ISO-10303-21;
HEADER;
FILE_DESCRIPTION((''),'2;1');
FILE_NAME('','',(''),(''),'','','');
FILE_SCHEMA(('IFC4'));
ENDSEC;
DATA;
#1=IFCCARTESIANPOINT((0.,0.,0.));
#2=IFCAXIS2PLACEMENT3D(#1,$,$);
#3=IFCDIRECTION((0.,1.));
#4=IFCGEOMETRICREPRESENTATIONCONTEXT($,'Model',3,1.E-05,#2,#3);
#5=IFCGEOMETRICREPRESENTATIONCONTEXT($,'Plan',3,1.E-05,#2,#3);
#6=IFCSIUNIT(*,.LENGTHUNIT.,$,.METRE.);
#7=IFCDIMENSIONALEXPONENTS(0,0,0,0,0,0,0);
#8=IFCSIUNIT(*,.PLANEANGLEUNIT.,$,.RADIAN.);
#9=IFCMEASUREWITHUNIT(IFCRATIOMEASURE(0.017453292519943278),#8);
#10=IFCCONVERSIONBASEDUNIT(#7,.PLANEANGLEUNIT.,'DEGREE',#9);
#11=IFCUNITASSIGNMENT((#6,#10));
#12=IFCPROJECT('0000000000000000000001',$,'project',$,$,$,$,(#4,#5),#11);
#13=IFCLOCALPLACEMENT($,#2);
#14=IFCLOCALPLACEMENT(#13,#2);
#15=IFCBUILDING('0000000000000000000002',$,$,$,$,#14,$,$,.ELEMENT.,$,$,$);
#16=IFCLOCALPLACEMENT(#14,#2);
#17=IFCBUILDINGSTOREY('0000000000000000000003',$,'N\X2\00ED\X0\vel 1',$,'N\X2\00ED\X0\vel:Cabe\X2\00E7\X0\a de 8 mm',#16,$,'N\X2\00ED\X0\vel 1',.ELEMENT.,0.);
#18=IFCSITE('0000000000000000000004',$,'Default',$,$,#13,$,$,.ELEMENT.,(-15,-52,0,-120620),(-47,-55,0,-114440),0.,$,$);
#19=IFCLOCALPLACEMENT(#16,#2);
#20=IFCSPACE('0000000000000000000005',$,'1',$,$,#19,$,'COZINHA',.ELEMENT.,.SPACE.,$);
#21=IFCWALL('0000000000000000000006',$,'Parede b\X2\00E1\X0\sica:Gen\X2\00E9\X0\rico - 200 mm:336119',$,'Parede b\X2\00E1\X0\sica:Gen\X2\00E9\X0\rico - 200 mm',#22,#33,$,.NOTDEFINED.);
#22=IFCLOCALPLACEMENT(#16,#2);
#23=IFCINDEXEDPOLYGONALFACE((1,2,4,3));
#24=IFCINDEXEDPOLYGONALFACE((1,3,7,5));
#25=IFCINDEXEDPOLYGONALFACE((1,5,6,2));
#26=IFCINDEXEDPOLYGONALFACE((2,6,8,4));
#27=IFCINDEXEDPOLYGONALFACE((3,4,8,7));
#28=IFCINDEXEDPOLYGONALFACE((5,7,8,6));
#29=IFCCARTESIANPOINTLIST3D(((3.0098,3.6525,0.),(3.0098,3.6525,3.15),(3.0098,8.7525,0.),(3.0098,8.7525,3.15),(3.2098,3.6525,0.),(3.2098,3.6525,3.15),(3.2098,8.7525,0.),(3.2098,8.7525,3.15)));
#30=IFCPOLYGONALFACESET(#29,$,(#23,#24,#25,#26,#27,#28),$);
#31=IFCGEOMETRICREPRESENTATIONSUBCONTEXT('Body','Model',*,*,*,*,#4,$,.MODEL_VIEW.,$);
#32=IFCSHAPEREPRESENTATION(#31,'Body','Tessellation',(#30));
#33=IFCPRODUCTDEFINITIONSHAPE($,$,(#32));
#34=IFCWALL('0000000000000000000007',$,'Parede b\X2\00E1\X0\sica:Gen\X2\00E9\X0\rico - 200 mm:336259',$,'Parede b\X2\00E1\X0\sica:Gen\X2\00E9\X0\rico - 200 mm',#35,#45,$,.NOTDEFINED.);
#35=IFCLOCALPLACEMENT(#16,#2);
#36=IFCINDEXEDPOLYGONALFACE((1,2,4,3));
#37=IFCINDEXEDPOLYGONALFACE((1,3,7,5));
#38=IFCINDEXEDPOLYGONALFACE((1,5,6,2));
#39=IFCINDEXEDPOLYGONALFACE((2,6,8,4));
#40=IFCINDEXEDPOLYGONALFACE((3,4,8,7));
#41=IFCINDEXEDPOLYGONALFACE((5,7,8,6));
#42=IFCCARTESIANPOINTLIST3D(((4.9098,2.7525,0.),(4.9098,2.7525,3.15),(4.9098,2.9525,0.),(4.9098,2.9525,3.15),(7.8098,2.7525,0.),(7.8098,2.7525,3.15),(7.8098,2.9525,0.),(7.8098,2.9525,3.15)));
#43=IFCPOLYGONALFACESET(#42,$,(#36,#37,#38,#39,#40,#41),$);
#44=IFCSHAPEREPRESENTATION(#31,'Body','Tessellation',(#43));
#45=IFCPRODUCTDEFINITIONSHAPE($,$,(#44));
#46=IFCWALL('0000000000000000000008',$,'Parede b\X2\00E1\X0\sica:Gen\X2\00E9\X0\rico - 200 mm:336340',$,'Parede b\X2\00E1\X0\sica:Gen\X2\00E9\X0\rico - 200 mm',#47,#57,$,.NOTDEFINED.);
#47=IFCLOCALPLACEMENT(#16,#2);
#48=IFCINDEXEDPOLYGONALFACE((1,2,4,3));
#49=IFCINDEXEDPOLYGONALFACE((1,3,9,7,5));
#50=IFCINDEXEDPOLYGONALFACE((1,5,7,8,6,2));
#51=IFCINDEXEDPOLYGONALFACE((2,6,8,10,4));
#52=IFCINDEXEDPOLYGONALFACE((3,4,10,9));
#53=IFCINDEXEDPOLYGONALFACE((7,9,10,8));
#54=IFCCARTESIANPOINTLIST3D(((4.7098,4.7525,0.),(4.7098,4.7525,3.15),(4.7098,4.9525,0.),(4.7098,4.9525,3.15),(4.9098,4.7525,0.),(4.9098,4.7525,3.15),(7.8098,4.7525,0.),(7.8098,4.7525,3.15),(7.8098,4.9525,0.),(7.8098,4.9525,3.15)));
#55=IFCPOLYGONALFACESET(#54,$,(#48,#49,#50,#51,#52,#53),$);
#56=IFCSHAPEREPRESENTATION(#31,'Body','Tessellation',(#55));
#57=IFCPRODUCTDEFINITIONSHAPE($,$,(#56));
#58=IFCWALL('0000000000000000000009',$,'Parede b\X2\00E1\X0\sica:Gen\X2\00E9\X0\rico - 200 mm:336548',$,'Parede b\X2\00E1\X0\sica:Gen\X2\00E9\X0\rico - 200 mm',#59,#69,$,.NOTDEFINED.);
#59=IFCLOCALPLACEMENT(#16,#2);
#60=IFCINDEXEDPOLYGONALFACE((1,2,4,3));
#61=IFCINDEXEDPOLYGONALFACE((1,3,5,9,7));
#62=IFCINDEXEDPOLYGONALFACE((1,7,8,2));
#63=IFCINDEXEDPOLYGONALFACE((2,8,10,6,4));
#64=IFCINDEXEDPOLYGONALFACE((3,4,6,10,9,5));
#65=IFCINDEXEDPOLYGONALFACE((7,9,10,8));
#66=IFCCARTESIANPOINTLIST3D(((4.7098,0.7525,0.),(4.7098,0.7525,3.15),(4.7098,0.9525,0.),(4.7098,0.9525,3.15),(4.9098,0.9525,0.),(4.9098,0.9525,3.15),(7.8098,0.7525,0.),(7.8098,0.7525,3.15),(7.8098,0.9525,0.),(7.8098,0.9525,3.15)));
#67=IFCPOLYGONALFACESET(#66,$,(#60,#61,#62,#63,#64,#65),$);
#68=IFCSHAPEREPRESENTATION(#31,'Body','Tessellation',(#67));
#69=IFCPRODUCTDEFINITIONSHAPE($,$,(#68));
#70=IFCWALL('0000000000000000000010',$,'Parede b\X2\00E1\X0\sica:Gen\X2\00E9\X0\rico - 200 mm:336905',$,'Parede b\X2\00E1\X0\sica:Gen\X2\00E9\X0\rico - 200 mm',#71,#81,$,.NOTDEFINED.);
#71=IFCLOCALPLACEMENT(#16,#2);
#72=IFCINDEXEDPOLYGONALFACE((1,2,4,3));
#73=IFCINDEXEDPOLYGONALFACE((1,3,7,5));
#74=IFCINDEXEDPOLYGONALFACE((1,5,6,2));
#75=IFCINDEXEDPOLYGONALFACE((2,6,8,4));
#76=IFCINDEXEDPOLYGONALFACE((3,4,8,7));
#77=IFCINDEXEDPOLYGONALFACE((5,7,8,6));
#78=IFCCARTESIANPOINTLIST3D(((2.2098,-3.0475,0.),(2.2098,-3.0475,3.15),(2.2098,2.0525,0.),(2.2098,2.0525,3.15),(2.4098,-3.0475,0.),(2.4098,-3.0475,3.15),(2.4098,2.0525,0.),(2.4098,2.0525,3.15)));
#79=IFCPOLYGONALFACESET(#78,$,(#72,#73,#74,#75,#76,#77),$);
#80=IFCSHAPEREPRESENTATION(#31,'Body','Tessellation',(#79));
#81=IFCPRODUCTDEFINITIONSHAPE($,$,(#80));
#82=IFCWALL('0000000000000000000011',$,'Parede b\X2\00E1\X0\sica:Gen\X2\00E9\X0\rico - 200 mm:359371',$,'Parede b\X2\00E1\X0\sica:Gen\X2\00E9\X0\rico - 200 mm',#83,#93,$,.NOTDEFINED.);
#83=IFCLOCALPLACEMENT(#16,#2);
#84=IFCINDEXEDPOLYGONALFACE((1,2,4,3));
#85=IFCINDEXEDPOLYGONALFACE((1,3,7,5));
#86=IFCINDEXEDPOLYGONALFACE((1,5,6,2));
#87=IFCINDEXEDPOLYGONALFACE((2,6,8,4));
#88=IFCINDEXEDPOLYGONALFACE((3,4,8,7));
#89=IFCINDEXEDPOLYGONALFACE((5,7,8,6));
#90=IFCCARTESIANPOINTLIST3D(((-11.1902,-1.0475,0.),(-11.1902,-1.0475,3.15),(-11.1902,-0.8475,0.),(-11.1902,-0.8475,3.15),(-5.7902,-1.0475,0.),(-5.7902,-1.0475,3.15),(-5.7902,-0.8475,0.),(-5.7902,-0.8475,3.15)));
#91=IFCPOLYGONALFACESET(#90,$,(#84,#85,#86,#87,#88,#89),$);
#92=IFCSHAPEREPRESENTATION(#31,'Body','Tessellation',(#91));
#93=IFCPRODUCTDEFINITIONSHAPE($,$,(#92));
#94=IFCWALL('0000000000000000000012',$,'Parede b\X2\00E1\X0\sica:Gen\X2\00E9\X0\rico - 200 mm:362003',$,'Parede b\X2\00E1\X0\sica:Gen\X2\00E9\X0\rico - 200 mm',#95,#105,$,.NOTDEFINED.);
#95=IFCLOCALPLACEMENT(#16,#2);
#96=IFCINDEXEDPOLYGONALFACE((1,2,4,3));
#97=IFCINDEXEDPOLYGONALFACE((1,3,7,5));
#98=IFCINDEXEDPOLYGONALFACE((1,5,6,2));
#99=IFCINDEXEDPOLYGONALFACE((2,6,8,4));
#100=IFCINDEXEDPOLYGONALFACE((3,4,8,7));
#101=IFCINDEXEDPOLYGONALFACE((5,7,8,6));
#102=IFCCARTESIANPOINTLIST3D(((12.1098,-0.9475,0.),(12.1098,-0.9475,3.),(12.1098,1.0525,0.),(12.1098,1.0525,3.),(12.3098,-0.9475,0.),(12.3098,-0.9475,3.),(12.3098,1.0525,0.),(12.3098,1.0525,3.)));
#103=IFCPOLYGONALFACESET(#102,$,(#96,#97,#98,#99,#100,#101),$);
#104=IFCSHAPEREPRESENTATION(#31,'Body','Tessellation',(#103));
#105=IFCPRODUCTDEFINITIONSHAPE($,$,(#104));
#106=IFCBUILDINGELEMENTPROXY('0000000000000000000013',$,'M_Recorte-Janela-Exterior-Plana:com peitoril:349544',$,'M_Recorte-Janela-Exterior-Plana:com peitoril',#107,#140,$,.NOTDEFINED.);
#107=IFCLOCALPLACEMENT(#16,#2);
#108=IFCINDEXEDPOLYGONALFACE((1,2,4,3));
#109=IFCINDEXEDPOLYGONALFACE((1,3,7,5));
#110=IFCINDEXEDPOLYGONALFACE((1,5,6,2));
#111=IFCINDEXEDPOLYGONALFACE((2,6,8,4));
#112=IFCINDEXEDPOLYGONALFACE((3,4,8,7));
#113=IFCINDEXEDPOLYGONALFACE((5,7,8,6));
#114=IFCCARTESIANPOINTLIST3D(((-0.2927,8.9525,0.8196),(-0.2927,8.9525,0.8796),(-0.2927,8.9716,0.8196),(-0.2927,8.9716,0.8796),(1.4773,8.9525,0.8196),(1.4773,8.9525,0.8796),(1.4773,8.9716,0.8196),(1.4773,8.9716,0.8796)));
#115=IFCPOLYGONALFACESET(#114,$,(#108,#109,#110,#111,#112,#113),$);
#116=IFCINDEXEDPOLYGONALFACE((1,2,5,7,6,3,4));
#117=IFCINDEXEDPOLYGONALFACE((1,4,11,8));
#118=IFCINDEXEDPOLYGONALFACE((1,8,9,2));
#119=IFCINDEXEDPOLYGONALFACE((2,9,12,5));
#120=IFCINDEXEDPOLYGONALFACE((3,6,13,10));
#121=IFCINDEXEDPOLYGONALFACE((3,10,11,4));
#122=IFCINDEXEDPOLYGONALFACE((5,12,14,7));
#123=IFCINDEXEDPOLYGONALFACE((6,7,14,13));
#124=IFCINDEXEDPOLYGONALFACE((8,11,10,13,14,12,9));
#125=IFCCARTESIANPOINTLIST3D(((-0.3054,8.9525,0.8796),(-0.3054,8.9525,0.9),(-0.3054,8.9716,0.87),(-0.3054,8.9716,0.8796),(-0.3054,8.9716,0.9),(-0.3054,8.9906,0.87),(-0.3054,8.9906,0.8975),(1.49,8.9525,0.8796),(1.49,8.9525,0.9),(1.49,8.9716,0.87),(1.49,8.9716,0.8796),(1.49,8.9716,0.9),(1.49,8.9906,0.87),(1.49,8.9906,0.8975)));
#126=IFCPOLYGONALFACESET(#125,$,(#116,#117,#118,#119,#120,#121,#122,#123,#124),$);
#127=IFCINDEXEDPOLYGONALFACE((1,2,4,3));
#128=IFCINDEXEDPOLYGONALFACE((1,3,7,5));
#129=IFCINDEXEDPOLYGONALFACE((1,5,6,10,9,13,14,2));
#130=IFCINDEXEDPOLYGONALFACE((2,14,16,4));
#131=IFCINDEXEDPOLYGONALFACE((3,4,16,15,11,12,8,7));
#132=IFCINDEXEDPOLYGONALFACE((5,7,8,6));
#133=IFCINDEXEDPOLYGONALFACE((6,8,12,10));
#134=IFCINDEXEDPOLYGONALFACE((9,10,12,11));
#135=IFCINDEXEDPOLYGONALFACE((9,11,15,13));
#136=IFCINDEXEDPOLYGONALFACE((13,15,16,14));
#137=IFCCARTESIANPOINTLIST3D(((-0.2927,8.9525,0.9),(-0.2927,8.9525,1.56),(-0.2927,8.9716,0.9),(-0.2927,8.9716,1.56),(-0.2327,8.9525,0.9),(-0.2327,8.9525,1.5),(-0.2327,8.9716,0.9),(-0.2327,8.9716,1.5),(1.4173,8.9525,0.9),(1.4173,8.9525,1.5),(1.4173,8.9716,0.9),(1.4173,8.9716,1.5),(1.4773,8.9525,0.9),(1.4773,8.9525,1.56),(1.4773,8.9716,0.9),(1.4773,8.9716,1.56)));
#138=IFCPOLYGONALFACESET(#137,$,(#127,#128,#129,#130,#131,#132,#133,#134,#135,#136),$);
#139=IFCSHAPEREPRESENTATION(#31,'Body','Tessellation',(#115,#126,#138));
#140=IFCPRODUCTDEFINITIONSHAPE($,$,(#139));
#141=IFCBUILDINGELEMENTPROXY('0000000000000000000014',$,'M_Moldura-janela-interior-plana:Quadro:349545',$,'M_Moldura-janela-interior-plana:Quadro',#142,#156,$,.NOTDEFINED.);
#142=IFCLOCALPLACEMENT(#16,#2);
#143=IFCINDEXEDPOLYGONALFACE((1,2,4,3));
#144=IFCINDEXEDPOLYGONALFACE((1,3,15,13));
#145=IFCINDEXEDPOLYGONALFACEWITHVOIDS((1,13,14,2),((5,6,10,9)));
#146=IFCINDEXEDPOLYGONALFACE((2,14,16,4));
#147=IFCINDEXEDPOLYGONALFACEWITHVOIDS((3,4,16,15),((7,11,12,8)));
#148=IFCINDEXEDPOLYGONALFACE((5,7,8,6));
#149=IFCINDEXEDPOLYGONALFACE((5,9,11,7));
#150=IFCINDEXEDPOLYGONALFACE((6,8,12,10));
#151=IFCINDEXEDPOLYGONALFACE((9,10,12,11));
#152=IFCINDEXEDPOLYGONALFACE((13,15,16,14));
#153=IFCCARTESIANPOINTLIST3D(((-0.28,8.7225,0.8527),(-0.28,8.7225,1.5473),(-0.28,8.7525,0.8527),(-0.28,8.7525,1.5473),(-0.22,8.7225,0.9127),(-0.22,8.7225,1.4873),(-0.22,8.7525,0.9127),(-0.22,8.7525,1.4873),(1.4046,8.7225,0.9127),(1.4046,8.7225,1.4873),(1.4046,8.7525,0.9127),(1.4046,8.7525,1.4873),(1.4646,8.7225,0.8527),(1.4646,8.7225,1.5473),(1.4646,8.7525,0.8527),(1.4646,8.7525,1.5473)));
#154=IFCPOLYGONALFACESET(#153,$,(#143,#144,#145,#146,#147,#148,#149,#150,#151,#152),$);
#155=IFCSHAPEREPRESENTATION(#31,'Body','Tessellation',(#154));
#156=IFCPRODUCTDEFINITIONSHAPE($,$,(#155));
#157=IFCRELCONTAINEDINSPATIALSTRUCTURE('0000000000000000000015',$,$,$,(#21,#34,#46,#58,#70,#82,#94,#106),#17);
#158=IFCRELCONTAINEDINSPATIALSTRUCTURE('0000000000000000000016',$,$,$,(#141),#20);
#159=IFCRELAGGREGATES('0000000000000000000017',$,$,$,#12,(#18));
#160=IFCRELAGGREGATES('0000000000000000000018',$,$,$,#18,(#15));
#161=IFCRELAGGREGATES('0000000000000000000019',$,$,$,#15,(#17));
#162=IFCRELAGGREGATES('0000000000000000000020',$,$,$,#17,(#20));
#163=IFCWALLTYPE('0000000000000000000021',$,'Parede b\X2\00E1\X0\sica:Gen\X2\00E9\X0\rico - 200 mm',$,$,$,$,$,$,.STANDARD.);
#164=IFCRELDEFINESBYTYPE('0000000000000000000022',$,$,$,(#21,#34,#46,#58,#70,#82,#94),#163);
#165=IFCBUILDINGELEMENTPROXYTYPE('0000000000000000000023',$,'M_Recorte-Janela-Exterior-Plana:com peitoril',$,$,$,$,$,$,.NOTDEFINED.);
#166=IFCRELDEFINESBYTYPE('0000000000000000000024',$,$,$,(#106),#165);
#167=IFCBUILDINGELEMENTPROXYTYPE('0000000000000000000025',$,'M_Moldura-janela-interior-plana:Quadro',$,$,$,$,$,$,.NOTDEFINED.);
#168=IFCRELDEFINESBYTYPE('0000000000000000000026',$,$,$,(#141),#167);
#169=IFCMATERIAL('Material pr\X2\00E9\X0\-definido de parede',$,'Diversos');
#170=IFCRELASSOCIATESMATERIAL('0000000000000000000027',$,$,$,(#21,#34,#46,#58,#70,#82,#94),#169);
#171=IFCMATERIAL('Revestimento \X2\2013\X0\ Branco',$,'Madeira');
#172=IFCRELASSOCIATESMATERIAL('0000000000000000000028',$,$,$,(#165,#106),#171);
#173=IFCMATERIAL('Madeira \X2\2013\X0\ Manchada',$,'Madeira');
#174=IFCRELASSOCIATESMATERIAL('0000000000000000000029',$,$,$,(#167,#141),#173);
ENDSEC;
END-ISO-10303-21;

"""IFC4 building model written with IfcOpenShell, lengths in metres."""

from ifc_helpers import new_model, entity, si_unit, converted_unit, direction, frame, origin, place, context, subcontext, project, spatial, indexed_curve, outline, extrude, source, transform, mapped, material, type_object, type_shapes, element, save


model = new_model("IFC4")

# Units and contexts
model_context = context("Model", 3, precision=1e-05, world=origin(), true_north=direction((0.0, 1.0)))
plan_context = context("Plan", 3, precision=1e-05, world=origin(), true_north=direction((0.0, 1.0)))
body_context = subcontext(model_context, "Body", "Model", "MODEL_VIEW")
ifc_project = project(units=[si_unit("LENGTHUNIT", "METRE"), converted_unit("PLANEANGLEUNIT", "DEGREE", entity("IfcRatioMeasure", 0.017453292519943278), si_unit("PLANEANGLEUNIT", "RADIAN"), dimensions=[0, 0, 0, 0, 0, 0, 0])], contexts=[model_context, plan_context])

# Site, building, storey
site_placement = place(None, origin())
site = spatial("IfcSite", under=ifc_project, at=site_placement, Name="Default", CompositionType="ELEMENT", RefLatitude=(-15, -52, 0, -120620), RefLongitude=(-47, -55, 0, -114440), RefElevation=0.0)
building_placement = place(site_placement, origin())
building = spatial("IfcBuilding", under=site, at=building_placement, CompositionType="ELEMENT")
storey_placement = place(building_placement, origin())
storey = spatial("IfcBuildingStorey", under=building, at=storey_placement, Name="Nível 1", ObjectType="Nível:Cabeça de 8 mm", LongName="Nível 1", CompositionType="ELEMENT", Elevation=0.0)

# Walls
ifc_material_1 = material(Name="Material pré-definido de parede", Category="Diversos")
wall_type = type_object("IfcWallType", Name="Parede básica:Genérico - 200 mm", PredefinedType="STANDARD")
wall_1_placement = place(storey_placement, frame((3.1098, 8.7525, 0.0), z_axis=(0.0, 0.0, 1.0), x_axis=(0.0, -1.0, 0.0)))
element("IfcWall", 1, at=wall_1_placement, inside=storey, type_object=wall_type, material=ifc_material_1, Name="Parede básica:Genérico - 200 mm:336119", ObjectType="Parede básica:Genérico - 200 mm", PredefinedType="NOTDEFINED", context=body_context, shape_type="SweptSolid", body=[
    extrude(outline(indexed_curve([(5.1, -0.1), (5.1, 0.1), (0.0, 0.1), (0.0, -0.1), (5.1, -0.1)], self_intersect=False)), origin(), (0.0, 0.0, 1.0), 3.15),
])
wall_2_placement = place(storey_placement, frame((7.8098, 2.8525, 0.0), z_axis=(0.0, 0.0, 1.0), x_axis=(-1.0, 0.0, 0.0)))
element("IfcWall", 2, at=wall_2_placement, inside=storey, type_object=wall_type, material=ifc_material_1, Name="Parede básica:Genérico - 200 mm:336259", ObjectType="Parede básica:Genérico - 200 mm", PredefinedType="NOTDEFINED", context=body_context, shape_type="SweptSolid", body=[
    extrude(outline(indexed_curve([(2.9, -0.1), (2.9, 0.1), (0.0, 0.1), (0.0, -0.1), (2.9, -0.1)], self_intersect=False)), origin(), (0.0, 0.0, 1.0), 3.15),
])
wall_3_placement = place(storey_placement, frame((7.8098, 4.8525, 0.0), z_axis=(0.0, 0.0, 1.0), x_axis=(-1.0, 0.0, 0.0)))
element("IfcWall", 3, at=wall_3_placement, inside=storey, type_object=wall_type, material=ifc_material_1, Name="Parede básica:Genérico - 200 mm:336340", ObjectType="Parede básica:Genérico - 200 mm", PredefinedType="NOTDEFINED", context=body_context, shape_type="SweptSolid", body=[
    extrude(outline(indexed_curve([(3.1, -0.1), (3.1, 0.1), (2.9, 0.1), (0.0, 0.1), (0.0, -0.1), (3.1, -0.1)], self_intersect=False)), origin(), (0.0, 0.0, 1.0), 3.15),
])
wall_4_placement = place(storey_placement, frame((7.8098, 0.8525, 0.0), z_axis=(0.0, 0.0, 1.0), x_axis=(-1.0, 0.0, 0.0)))
element("IfcWall", 4, at=wall_4_placement, inside=storey, type_object=wall_type, material=ifc_material_1, Name="Parede básica:Genérico - 200 mm:336548", ObjectType="Parede básica:Genérico - 200 mm", PredefinedType="NOTDEFINED", context=body_context, shape_type="SweptSolid", body=[
    extrude(outline(indexed_curve([(3.1, -0.1), (3.1, 0.1), (0.0, 0.1), (0.0, -0.1), (2.9, -0.1), (3.1, -0.1)], self_intersect=False)), origin(), (0.0, 0.0, 1.0), 3.15),
])
wall_5_placement = place(storey_placement, frame((2.3098, 2.0525, 0.0), z_axis=(0.0, 0.0, 1.0), x_axis=(0.0, -1.0, 0.0)))
element("IfcWall", 5, at=wall_5_placement, inside=storey, type_object=wall_type, material=ifc_material_1, Name="Parede básica:Genérico - 200 mm:336905", ObjectType="Parede básica:Genérico - 200 mm", PredefinedType="NOTDEFINED", context=body_context, shape_type="SweptSolid", body=[
    extrude(outline(indexed_curve([(5.1, -0.1), (5.1, 0.1), (0.0, 0.1), (0.0, -0.1), (5.1, -0.1)], self_intersect=False)), origin(), (0.0, 0.0, 1.0), 3.15),
])
wall_6_placement = place(storey_placement, frame((-11.1902, -0.9475, 0.0)))
element("IfcWall", 6, at=wall_6_placement, inside=storey, type_object=wall_type, material=ifc_material_1, Name="Parede básica:Genérico - 200 mm:359371", ObjectType="Parede básica:Genérico - 200 mm", PredefinedType="NOTDEFINED", context=body_context, shape_type="SweptSolid", body=[
    extrude(outline(indexed_curve([(5.4, -0.1), (5.4, 0.1), (0.0, 0.1), (0.0, -0.1), (5.4, -0.1)], self_intersect=False)), origin(), (0.0, 0.0, 1.0), 3.15),
])
wall_7_placement = place(storey_placement, frame((12.2098, -0.9475, 0.0), z_axis=(0.0, 0.0, 1.0), x_axis=(0.0, 1.0, 0.0)))
element("IfcWall", 7, at=wall_7_placement, inside=storey, type_object=wall_type, material=ifc_material_1, Name="Parede básica:Genérico - 200 mm:362003", ObjectType="Parede básica:Genérico - 200 mm", PredefinedType="NOTDEFINED", context=body_context, shape_type="SweptSolid", body=[
    extrude(outline(indexed_curve([(2.0, -0.1), (2.0, 0.1), (0.0, 0.1), (0.0, -0.1), (2.0, -0.1)], self_intersect=False)), origin(), (0.0, 0.0, 1.0), 3.0),
])

# Building element proxy
ifc_material_2 = material(Name="Revestimento – Branco", Category="Madeira")
building_element_proxy_type_1 = type_object("IfcBuildingElementProxyType", Name="M_Recorte-Janela-Exterior-Plana:com peitoril", PredefinedType="NOTDEFINED", material=ifc_material_2)
shared_shape_1 = source(origin(), body_context, "Body", "SweptSolid", [
    extrude(outline(indexed_curve([(-0.03, -0.885), (0.03, -0.885), (0.03, 0.885), (-0.03, 0.885), (-0.03, -0.885)], self_intersect=False)), frame((0.0, 0.6504, 0.0), z_axis=(0.0, 0.0, 1.0), x_axis=(0.0, 1.0, 0.0)), (0.0, 0.0, 1.0), 0.019),
    extrude(outline(indexed_curve([(-0.0152, -0.019), (0.0123, -0.019), (0.0148, 0.0), (0.0148, 0.019), (-0.0057, 0.019), (-0.0057, 0.0), (-0.0152, 0.0), (-0.0152, -0.019)], self_intersect=False)), frame((-0.8977, 0.6148, 0.019), z_axis=(1.0, 0.0, 0.0), x_axis=(0.0, -1.0, 0.0)), (0.0, 0.0, 1.0), 1.7954),
    extrude(outline(indexed_curve([(-0.885, -0.345), (0.885, -0.345), (0.885, 0.315), (0.825, 0.315), (0.825, -0.285), (-0.825, -0.285), (-0.825, 0.315), (-0.885, 0.315), (-0.885, -0.345)], self_intersect=False)), frame((0.0, 0.285, 0.0)), (0.0, 0.0, 1.0), 0.019),
])
type_shapes(building_element_proxy_type_1, [shared_shape_1])
proxy_1_placement = place(storey_placement, frame((0.5923, 8.9525, 1.5), z_axis=(0.0, 1.0, 0.0), x_axis=(1.0, 0.0, 0.0)))
element("IfcBuildingElementProxy", 8, at=proxy_1_placement, inside=storey, type_object=building_element_proxy_type_1, material=ifc_material_2, Name="M_Recorte-Janela-Exterior-Plana:com peitoril:349544", ObjectType="M_Recorte-Janela-Exterior-Plana:com peitoril", PredefinedType="NOTDEFINED", context=body_context, shape_type="MappedRepresentation", body=[
    mapped(shared_shape_1, transform((0.0, 0.0, 0.0), scale=1.0)),
])

# Shared definitions
space_1_placement = place(storey_placement, origin())
space_1 = spatial("IfcSpace", under=storey, at=space_1_placement, Name="1", LongName="COZINHA", CompositionType="ELEMENT", PredefinedType="SPACE")

# Building element proxy
ifc_material_3 = material(Name="Madeira – Manchada", Category="Madeira")
building_element_proxy_type_2 = type_object("IfcBuildingElementProxyType", Name="M_Moldura-janela-interior-plana:Quadro", PredefinedType="NOTDEFINED", material=ifc_material_3)
shared_shape_2 = source(origin(), body_context, "Body", "SweptSolid", [
    extrude(outline(indexed_curve([(-0.3473, -0.8723), (0.3473, -0.8723), (0.3473, 0.8723), (-0.3473, 0.8723), (-0.3473, -0.8723)], self_intersect=False), holes=[indexed_curve([(-0.2873, -0.8123), (-0.2873, 0.8123), (0.2873, 0.8123), (0.2873, -0.8123), (-0.2873, -0.8123)], self_intersect=False)]), frame((0.0, 0.3, 0.0), z_axis=(0.0, 0.0, 1.0), x_axis=(0.0, 1.0, 0.0)), (0.0, 0.0, 1.0), 0.03),
])
type_shapes(building_element_proxy_type_2, [shared_shape_2])
proxy_2_placement = place(space_1_placement, frame((0.5923, 8.7525, 1.5), z_axis=(0.0, -1.0, 0.0), x_axis=(-1.0, 0.0, 0.0)))
element("IfcBuildingElementProxy", 9, at=proxy_2_placement, inside=space_1, type_object=building_element_proxy_type_2, material=ifc_material_3, Name="M_Moldura-janela-interior-plana:Quadro:349545", ObjectType="M_Moldura-janela-interior-plana:Quadro", PredefinedType="NOTDEFINED", context=body_context, shape_type="MappedRepresentation", body=[
    mapped(shared_shape_2, transform((0.0, 0.0, 0.0), scale=1.0)),
])

save(model, "model.ifc")
